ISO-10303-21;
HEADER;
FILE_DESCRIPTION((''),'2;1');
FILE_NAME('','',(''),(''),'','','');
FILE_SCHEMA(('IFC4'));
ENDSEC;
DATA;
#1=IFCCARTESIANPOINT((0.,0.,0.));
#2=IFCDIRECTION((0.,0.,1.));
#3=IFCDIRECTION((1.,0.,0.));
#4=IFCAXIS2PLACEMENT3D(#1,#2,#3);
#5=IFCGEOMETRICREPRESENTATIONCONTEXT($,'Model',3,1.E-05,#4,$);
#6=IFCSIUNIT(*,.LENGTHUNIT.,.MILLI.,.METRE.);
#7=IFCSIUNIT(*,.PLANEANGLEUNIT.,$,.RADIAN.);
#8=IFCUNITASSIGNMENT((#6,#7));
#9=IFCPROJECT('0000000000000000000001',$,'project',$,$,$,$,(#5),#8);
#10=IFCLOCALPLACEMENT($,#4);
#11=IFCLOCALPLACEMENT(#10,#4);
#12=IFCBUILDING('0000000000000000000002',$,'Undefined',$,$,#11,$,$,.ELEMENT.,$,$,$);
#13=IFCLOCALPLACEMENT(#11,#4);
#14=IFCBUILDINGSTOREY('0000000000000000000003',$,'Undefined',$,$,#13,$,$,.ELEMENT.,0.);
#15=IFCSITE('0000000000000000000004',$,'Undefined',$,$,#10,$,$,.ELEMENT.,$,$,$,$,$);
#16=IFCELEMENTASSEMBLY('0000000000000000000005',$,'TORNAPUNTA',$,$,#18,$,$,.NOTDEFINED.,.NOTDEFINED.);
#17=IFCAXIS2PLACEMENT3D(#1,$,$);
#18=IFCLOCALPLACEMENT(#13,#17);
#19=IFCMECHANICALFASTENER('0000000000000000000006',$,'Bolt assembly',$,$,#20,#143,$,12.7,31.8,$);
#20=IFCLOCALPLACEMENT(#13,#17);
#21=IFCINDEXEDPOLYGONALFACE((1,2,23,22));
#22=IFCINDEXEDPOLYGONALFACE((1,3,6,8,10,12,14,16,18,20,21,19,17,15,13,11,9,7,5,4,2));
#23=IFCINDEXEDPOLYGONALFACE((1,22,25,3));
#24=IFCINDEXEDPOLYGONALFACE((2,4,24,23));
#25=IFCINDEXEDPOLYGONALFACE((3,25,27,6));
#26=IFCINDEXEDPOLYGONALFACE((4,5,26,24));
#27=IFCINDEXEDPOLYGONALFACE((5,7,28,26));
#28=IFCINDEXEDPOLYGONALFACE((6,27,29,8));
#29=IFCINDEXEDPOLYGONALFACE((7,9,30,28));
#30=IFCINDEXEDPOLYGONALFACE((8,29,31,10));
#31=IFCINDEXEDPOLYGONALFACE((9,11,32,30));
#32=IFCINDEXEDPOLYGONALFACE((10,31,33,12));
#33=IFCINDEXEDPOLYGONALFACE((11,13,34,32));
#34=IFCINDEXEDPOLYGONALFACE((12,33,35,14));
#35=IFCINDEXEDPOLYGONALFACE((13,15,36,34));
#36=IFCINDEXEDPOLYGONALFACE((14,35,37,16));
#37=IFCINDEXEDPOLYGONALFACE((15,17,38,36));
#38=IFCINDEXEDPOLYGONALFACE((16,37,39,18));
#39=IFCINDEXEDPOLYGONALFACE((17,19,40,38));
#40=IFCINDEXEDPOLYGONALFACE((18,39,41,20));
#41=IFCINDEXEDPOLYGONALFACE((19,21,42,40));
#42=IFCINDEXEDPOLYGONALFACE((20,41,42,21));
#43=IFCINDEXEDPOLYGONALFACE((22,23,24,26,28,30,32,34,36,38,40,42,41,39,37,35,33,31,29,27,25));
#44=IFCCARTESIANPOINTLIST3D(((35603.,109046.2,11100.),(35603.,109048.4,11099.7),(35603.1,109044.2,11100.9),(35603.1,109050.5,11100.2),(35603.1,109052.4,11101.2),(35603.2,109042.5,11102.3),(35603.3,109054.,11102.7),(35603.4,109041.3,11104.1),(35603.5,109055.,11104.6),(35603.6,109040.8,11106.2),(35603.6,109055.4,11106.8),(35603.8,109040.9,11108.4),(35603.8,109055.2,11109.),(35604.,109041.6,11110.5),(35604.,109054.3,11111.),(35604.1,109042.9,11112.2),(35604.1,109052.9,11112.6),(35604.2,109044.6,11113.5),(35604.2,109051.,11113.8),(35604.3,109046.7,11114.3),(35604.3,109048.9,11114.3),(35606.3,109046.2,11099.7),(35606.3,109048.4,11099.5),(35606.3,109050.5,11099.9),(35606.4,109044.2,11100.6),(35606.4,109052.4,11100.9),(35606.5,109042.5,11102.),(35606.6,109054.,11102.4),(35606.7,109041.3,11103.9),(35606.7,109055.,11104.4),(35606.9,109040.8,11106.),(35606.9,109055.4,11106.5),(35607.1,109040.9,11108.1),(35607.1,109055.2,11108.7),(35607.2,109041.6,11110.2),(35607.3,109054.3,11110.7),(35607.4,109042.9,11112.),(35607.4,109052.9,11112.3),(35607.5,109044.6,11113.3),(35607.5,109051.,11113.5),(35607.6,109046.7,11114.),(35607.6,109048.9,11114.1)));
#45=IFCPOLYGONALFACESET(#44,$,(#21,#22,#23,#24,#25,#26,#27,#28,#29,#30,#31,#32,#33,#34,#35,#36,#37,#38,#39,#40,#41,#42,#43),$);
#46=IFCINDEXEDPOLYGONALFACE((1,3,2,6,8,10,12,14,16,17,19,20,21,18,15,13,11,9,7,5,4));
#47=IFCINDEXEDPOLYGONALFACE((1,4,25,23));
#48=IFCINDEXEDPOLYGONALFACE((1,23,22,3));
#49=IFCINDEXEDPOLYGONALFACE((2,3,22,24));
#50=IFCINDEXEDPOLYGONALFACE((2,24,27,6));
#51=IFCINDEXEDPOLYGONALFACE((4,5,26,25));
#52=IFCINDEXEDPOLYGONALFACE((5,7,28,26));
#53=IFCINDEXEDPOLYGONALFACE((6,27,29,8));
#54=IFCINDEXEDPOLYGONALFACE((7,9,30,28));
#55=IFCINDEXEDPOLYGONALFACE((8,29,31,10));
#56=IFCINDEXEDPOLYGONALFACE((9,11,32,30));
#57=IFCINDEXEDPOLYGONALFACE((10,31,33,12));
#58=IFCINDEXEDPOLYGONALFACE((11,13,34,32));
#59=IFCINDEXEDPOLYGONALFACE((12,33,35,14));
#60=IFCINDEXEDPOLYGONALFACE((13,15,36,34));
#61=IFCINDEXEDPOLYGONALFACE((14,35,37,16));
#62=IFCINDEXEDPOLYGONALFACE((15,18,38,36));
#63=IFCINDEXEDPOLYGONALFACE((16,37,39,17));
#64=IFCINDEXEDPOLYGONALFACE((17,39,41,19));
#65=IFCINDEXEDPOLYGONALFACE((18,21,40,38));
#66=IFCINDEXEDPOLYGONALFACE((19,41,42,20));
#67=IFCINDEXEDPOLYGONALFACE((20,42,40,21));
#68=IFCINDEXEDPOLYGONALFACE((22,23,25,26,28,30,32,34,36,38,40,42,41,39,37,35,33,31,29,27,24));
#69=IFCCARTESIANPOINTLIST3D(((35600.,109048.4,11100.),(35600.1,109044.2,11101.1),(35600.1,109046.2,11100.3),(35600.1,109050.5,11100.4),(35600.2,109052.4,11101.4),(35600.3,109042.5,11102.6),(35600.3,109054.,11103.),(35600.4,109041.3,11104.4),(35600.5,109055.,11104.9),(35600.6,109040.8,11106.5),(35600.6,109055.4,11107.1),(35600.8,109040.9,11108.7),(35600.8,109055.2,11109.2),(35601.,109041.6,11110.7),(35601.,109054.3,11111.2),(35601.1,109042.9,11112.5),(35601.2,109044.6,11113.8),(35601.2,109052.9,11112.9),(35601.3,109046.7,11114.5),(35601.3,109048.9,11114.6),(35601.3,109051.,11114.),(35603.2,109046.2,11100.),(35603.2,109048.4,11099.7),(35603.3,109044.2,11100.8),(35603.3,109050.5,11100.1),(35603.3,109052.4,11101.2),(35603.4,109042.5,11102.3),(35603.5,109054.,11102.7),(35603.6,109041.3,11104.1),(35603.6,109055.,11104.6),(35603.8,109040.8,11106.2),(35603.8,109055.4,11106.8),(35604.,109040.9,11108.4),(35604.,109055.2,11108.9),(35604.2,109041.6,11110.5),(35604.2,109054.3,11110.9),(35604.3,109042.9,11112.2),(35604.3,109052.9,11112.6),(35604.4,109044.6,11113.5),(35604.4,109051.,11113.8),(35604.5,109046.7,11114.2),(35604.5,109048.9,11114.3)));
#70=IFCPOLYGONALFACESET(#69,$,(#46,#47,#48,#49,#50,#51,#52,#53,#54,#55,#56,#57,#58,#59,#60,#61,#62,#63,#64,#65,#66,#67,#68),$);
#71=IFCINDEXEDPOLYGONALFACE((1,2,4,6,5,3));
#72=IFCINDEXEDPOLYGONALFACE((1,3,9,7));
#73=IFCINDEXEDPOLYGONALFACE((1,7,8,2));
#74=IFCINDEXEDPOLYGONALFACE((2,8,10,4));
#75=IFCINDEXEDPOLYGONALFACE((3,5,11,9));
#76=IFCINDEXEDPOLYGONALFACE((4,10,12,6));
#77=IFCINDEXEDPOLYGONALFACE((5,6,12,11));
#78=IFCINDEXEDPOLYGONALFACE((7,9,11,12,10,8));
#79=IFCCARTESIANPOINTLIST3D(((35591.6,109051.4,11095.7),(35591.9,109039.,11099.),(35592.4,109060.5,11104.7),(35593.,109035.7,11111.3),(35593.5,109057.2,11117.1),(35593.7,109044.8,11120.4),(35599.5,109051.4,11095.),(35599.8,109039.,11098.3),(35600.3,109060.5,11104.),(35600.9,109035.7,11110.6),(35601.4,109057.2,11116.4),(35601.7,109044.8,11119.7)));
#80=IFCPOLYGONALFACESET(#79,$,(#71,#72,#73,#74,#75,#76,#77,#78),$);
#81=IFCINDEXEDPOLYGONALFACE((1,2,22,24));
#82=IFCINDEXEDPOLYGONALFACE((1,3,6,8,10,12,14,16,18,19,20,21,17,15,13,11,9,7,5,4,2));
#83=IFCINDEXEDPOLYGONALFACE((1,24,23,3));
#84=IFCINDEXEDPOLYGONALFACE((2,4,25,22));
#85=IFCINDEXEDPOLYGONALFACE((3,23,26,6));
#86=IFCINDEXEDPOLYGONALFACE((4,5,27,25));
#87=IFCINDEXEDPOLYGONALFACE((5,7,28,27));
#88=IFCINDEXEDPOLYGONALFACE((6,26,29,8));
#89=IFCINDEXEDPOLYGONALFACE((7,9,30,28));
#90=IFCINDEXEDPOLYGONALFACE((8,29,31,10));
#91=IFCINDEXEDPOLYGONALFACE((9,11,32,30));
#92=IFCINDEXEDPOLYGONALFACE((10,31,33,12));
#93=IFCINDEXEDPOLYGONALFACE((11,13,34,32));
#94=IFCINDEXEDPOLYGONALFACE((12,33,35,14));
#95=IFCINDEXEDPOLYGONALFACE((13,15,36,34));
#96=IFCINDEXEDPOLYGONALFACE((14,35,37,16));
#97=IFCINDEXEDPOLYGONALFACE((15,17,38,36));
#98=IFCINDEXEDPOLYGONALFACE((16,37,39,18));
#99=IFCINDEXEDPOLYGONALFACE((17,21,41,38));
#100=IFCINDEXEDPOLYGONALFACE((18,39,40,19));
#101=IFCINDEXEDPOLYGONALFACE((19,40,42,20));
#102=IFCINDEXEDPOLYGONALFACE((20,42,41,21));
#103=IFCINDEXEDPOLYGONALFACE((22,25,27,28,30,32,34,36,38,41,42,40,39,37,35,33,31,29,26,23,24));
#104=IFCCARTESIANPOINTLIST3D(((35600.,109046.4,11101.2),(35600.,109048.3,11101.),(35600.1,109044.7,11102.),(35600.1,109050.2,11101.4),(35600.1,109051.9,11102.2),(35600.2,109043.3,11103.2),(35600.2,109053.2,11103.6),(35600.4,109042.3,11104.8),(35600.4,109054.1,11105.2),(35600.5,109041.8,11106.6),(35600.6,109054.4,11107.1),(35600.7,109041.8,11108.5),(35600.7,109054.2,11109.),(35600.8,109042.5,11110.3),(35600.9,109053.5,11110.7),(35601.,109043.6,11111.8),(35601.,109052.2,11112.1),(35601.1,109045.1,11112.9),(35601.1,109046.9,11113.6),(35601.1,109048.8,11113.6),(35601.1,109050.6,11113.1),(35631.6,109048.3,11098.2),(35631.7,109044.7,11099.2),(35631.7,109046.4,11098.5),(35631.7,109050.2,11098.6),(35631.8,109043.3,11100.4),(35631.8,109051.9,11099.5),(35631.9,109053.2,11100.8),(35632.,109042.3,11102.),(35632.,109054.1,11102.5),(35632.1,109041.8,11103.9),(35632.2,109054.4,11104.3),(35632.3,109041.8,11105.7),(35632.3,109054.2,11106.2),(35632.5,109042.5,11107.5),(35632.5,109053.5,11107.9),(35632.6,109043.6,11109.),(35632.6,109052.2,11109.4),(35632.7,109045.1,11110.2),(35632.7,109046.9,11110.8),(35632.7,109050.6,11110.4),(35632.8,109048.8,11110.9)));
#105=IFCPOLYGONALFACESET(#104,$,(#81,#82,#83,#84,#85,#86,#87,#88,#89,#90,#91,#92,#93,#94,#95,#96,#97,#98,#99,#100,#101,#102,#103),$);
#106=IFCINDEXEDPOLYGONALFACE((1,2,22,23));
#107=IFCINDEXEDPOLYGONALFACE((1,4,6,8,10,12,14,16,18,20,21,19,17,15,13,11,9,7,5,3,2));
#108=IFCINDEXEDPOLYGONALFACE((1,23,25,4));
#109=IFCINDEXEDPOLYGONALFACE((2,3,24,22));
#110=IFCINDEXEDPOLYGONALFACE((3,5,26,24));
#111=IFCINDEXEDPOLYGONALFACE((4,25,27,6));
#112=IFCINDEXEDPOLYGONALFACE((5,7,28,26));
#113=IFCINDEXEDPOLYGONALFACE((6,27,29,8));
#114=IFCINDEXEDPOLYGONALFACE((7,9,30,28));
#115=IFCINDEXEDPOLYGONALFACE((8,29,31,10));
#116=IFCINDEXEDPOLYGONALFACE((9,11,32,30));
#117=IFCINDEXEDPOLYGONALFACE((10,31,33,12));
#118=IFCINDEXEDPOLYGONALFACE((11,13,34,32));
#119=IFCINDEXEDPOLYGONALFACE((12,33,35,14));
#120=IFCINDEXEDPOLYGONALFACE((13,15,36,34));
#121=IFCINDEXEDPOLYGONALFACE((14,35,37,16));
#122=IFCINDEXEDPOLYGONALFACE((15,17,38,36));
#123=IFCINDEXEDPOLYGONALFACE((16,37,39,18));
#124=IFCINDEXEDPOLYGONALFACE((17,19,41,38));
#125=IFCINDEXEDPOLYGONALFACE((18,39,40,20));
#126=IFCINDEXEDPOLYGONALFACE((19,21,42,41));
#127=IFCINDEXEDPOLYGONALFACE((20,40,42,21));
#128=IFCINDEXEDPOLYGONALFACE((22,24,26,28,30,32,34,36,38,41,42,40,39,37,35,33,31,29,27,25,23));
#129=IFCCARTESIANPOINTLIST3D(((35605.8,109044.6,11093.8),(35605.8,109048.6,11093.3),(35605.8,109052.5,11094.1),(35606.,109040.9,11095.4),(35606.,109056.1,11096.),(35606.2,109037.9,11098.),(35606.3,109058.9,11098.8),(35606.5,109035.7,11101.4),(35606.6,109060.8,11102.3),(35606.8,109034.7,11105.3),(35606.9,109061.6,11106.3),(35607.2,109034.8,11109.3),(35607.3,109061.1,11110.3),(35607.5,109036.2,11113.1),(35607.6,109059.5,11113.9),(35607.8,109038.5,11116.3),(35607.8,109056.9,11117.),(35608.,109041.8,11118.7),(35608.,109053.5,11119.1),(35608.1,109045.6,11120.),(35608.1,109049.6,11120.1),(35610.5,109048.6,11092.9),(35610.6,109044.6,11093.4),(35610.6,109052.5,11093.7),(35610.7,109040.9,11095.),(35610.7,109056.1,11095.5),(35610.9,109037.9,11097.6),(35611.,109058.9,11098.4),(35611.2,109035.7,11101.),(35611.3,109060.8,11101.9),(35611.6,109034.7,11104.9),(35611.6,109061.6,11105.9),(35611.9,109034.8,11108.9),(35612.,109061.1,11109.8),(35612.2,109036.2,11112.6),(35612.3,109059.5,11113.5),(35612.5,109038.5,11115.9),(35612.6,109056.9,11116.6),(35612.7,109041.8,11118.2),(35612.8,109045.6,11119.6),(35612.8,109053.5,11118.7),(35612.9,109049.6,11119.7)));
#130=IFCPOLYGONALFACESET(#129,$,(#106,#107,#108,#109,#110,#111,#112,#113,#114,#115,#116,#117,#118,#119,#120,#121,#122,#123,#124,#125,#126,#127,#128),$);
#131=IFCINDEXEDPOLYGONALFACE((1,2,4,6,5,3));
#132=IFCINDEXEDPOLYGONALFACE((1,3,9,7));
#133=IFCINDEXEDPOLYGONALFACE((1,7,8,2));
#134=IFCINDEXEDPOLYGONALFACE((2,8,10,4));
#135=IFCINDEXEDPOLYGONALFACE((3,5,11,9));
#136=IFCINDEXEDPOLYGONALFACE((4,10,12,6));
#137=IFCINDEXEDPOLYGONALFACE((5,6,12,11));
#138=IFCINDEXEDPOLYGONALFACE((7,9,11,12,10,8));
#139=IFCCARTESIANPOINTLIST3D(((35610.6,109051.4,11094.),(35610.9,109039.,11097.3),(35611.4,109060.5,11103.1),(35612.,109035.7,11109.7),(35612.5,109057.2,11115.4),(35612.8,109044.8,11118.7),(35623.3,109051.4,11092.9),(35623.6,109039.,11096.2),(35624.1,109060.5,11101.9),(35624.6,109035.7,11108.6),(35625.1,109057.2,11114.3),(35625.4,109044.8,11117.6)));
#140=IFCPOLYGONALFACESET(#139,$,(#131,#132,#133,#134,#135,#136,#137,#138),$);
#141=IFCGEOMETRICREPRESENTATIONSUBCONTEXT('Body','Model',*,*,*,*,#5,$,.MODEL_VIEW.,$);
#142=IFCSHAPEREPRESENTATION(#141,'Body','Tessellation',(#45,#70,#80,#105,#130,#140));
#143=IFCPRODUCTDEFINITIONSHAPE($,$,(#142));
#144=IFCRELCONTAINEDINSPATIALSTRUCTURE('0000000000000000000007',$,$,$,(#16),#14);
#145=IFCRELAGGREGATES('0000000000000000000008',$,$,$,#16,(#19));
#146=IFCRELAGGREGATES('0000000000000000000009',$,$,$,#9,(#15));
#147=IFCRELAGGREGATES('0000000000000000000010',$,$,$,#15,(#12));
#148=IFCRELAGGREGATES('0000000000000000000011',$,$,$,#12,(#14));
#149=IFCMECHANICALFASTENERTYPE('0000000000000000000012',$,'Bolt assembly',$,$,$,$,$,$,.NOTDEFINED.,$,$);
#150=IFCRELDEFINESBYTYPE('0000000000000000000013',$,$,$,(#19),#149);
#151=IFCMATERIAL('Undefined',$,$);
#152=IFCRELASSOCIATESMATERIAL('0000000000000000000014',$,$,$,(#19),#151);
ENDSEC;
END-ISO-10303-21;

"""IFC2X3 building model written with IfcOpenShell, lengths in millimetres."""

from ifc_helpers import new_model, si_unit, frame, origin_with_axes, origin_2d_with_axis, place, context, subcontext, project, spatial, polyline, circle, outline, extrude, source, transform, mapped, material, type_object, element, aggregate, save


model = new_model("IFC2X3")

# Units and contexts
model_context = context("Model", 3, precision=1e-05, world=origin_with_axes())
body_context = subcontext(model_context, "Body", "Model", "MODEL_VIEW")
ifc_project = project(units=[si_unit("LENGTHUNIT", "METRE", prefix="MILLI"), si_unit("PLANEANGLEUNIT", "RADIAN")], contexts=[model_context])

# Site, building, storey
site_placement = place(None, origin_with_axes())
site = spatial("IfcSite", under=ifc_project, at=site_placement, Name="Undefined", CompositionType="ELEMENT")
building_placement = place(site_placement, origin_with_axes())
building = spatial("IfcBuilding", under=site, at=building_placement, Name="Undefined", CompositionType="ELEMENT")
storey_placement = place(building_placement, origin_with_axes())
storey = spatial("IfcBuildingStorey", under=building, at=storey_placement, Name="Undefined", CompositionType="ELEMENT", Elevation=0.0)

# Element assembly, mechanical fastener
assembly_1_placement = place(storey_placement, origin_with_axes())
assembly_1 = element("IfcElementAssembly", 1, at=assembly_1_placement, inside=storey, Name="TORNAPUNTA", AssemblyPlace="NOTDEFINED", PredefinedType="NOTDEFINED")
ifc_material_1 = material(Name="Undefined")
mechanical_fastener_type = type_object("IfcMechanicalFastenerType", Name="Bolt assembly")
shared_shape_1 = source(origin_with_axes(), body_context, "Body", "SweptSolid", [
    extrude(circle(Radius=7.3, at=origin_2d_with_axis()), frame((0.0, -0.1, 0.0), z_axis=(0.0, 1.0, 0.0), x_axis=(1.0, 0.0, 0.0)), (0.0, 0.0, 1.0), 3.3),
    extrude(circle(Radius=7.3, at=origin_2d_with_axis()), frame((0.0, -3.1, 0.0), z_axis=(0.0, 1.0, 0.0), x_axis=(1.0, 0.0, 0.0)), (0.0, 0.0, 1.0), 3.2),
    extrude(outline(polyline([(11.1, -6.4), (11.1, 6.4), (0.0, 12.8), (-11.1, 6.4), (-11.1, -6.4), (0.0, -12.8), (11.1, -6.4)])), frame((0.0, -11.1, 0.0), z_axis=(0.0, 1.0, 0.0), x_axis=(1.0, 0.0, 0.0)), (0.0, 0.0, 1.0), 7.9),
    extrude(circle(Radius=6.3, at=origin_2d_with_axis()), frame((0.0, -3.2, 0.0), z_axis=(0.0, 1.0, 0.0), x_axis=(1.0, 0.0, 0.0)), (0.0, 0.0, 1.0), 31.8),
    extrude(circle(Radius=13.5, at=origin_2d_with_axis()), frame((0.0, 3.2, 0.0), z_axis=(0.0, 1.0, 0.0), x_axis=(1.0, 0.0, 0.0)), (0.0, 0.0, 1.0), 4.8),
    extrude(outline(polyline([(11.1, -6.4), (11.1, 6.4), (0.0, 12.8), (-11.1, 6.4), (-11.1, -6.4), (0.0, -12.8), (11.1, -6.4)])), frame((0.0, 8.0, 0.0), z_axis=(0.0, 1.0, 0.0), x_axis=(1.0, 0.0, 0.0)), (0.0, 0.0, 1.0), 12.7),
])
mechanical_fastener_1_placement = place(assembly_1_placement, frame((35603.8, 109048.1, 11107.1), z_axis=(0.061628, 0.707107, 0.704416), x_axis=(0.061628, -0.707107, 0.704416)))
mechanical_fastener_1 = element("IfcMechanicalFastener", 2, at=mechanical_fastener_1_placement, type_object=mechanical_fastener_type, material=ifc_material_1, Name="Bolt assembly", NominalDiameter=12.7, NominalLength=31.8, context=body_context, shape_type="MappedRepresentation", body=[
    mapped(shared_shape_1, transform((0.0, 0.0, 0.0))),
])
aggregate(assembly_1, [mechanical_fastener_1])

save(model, "model.ifc")
